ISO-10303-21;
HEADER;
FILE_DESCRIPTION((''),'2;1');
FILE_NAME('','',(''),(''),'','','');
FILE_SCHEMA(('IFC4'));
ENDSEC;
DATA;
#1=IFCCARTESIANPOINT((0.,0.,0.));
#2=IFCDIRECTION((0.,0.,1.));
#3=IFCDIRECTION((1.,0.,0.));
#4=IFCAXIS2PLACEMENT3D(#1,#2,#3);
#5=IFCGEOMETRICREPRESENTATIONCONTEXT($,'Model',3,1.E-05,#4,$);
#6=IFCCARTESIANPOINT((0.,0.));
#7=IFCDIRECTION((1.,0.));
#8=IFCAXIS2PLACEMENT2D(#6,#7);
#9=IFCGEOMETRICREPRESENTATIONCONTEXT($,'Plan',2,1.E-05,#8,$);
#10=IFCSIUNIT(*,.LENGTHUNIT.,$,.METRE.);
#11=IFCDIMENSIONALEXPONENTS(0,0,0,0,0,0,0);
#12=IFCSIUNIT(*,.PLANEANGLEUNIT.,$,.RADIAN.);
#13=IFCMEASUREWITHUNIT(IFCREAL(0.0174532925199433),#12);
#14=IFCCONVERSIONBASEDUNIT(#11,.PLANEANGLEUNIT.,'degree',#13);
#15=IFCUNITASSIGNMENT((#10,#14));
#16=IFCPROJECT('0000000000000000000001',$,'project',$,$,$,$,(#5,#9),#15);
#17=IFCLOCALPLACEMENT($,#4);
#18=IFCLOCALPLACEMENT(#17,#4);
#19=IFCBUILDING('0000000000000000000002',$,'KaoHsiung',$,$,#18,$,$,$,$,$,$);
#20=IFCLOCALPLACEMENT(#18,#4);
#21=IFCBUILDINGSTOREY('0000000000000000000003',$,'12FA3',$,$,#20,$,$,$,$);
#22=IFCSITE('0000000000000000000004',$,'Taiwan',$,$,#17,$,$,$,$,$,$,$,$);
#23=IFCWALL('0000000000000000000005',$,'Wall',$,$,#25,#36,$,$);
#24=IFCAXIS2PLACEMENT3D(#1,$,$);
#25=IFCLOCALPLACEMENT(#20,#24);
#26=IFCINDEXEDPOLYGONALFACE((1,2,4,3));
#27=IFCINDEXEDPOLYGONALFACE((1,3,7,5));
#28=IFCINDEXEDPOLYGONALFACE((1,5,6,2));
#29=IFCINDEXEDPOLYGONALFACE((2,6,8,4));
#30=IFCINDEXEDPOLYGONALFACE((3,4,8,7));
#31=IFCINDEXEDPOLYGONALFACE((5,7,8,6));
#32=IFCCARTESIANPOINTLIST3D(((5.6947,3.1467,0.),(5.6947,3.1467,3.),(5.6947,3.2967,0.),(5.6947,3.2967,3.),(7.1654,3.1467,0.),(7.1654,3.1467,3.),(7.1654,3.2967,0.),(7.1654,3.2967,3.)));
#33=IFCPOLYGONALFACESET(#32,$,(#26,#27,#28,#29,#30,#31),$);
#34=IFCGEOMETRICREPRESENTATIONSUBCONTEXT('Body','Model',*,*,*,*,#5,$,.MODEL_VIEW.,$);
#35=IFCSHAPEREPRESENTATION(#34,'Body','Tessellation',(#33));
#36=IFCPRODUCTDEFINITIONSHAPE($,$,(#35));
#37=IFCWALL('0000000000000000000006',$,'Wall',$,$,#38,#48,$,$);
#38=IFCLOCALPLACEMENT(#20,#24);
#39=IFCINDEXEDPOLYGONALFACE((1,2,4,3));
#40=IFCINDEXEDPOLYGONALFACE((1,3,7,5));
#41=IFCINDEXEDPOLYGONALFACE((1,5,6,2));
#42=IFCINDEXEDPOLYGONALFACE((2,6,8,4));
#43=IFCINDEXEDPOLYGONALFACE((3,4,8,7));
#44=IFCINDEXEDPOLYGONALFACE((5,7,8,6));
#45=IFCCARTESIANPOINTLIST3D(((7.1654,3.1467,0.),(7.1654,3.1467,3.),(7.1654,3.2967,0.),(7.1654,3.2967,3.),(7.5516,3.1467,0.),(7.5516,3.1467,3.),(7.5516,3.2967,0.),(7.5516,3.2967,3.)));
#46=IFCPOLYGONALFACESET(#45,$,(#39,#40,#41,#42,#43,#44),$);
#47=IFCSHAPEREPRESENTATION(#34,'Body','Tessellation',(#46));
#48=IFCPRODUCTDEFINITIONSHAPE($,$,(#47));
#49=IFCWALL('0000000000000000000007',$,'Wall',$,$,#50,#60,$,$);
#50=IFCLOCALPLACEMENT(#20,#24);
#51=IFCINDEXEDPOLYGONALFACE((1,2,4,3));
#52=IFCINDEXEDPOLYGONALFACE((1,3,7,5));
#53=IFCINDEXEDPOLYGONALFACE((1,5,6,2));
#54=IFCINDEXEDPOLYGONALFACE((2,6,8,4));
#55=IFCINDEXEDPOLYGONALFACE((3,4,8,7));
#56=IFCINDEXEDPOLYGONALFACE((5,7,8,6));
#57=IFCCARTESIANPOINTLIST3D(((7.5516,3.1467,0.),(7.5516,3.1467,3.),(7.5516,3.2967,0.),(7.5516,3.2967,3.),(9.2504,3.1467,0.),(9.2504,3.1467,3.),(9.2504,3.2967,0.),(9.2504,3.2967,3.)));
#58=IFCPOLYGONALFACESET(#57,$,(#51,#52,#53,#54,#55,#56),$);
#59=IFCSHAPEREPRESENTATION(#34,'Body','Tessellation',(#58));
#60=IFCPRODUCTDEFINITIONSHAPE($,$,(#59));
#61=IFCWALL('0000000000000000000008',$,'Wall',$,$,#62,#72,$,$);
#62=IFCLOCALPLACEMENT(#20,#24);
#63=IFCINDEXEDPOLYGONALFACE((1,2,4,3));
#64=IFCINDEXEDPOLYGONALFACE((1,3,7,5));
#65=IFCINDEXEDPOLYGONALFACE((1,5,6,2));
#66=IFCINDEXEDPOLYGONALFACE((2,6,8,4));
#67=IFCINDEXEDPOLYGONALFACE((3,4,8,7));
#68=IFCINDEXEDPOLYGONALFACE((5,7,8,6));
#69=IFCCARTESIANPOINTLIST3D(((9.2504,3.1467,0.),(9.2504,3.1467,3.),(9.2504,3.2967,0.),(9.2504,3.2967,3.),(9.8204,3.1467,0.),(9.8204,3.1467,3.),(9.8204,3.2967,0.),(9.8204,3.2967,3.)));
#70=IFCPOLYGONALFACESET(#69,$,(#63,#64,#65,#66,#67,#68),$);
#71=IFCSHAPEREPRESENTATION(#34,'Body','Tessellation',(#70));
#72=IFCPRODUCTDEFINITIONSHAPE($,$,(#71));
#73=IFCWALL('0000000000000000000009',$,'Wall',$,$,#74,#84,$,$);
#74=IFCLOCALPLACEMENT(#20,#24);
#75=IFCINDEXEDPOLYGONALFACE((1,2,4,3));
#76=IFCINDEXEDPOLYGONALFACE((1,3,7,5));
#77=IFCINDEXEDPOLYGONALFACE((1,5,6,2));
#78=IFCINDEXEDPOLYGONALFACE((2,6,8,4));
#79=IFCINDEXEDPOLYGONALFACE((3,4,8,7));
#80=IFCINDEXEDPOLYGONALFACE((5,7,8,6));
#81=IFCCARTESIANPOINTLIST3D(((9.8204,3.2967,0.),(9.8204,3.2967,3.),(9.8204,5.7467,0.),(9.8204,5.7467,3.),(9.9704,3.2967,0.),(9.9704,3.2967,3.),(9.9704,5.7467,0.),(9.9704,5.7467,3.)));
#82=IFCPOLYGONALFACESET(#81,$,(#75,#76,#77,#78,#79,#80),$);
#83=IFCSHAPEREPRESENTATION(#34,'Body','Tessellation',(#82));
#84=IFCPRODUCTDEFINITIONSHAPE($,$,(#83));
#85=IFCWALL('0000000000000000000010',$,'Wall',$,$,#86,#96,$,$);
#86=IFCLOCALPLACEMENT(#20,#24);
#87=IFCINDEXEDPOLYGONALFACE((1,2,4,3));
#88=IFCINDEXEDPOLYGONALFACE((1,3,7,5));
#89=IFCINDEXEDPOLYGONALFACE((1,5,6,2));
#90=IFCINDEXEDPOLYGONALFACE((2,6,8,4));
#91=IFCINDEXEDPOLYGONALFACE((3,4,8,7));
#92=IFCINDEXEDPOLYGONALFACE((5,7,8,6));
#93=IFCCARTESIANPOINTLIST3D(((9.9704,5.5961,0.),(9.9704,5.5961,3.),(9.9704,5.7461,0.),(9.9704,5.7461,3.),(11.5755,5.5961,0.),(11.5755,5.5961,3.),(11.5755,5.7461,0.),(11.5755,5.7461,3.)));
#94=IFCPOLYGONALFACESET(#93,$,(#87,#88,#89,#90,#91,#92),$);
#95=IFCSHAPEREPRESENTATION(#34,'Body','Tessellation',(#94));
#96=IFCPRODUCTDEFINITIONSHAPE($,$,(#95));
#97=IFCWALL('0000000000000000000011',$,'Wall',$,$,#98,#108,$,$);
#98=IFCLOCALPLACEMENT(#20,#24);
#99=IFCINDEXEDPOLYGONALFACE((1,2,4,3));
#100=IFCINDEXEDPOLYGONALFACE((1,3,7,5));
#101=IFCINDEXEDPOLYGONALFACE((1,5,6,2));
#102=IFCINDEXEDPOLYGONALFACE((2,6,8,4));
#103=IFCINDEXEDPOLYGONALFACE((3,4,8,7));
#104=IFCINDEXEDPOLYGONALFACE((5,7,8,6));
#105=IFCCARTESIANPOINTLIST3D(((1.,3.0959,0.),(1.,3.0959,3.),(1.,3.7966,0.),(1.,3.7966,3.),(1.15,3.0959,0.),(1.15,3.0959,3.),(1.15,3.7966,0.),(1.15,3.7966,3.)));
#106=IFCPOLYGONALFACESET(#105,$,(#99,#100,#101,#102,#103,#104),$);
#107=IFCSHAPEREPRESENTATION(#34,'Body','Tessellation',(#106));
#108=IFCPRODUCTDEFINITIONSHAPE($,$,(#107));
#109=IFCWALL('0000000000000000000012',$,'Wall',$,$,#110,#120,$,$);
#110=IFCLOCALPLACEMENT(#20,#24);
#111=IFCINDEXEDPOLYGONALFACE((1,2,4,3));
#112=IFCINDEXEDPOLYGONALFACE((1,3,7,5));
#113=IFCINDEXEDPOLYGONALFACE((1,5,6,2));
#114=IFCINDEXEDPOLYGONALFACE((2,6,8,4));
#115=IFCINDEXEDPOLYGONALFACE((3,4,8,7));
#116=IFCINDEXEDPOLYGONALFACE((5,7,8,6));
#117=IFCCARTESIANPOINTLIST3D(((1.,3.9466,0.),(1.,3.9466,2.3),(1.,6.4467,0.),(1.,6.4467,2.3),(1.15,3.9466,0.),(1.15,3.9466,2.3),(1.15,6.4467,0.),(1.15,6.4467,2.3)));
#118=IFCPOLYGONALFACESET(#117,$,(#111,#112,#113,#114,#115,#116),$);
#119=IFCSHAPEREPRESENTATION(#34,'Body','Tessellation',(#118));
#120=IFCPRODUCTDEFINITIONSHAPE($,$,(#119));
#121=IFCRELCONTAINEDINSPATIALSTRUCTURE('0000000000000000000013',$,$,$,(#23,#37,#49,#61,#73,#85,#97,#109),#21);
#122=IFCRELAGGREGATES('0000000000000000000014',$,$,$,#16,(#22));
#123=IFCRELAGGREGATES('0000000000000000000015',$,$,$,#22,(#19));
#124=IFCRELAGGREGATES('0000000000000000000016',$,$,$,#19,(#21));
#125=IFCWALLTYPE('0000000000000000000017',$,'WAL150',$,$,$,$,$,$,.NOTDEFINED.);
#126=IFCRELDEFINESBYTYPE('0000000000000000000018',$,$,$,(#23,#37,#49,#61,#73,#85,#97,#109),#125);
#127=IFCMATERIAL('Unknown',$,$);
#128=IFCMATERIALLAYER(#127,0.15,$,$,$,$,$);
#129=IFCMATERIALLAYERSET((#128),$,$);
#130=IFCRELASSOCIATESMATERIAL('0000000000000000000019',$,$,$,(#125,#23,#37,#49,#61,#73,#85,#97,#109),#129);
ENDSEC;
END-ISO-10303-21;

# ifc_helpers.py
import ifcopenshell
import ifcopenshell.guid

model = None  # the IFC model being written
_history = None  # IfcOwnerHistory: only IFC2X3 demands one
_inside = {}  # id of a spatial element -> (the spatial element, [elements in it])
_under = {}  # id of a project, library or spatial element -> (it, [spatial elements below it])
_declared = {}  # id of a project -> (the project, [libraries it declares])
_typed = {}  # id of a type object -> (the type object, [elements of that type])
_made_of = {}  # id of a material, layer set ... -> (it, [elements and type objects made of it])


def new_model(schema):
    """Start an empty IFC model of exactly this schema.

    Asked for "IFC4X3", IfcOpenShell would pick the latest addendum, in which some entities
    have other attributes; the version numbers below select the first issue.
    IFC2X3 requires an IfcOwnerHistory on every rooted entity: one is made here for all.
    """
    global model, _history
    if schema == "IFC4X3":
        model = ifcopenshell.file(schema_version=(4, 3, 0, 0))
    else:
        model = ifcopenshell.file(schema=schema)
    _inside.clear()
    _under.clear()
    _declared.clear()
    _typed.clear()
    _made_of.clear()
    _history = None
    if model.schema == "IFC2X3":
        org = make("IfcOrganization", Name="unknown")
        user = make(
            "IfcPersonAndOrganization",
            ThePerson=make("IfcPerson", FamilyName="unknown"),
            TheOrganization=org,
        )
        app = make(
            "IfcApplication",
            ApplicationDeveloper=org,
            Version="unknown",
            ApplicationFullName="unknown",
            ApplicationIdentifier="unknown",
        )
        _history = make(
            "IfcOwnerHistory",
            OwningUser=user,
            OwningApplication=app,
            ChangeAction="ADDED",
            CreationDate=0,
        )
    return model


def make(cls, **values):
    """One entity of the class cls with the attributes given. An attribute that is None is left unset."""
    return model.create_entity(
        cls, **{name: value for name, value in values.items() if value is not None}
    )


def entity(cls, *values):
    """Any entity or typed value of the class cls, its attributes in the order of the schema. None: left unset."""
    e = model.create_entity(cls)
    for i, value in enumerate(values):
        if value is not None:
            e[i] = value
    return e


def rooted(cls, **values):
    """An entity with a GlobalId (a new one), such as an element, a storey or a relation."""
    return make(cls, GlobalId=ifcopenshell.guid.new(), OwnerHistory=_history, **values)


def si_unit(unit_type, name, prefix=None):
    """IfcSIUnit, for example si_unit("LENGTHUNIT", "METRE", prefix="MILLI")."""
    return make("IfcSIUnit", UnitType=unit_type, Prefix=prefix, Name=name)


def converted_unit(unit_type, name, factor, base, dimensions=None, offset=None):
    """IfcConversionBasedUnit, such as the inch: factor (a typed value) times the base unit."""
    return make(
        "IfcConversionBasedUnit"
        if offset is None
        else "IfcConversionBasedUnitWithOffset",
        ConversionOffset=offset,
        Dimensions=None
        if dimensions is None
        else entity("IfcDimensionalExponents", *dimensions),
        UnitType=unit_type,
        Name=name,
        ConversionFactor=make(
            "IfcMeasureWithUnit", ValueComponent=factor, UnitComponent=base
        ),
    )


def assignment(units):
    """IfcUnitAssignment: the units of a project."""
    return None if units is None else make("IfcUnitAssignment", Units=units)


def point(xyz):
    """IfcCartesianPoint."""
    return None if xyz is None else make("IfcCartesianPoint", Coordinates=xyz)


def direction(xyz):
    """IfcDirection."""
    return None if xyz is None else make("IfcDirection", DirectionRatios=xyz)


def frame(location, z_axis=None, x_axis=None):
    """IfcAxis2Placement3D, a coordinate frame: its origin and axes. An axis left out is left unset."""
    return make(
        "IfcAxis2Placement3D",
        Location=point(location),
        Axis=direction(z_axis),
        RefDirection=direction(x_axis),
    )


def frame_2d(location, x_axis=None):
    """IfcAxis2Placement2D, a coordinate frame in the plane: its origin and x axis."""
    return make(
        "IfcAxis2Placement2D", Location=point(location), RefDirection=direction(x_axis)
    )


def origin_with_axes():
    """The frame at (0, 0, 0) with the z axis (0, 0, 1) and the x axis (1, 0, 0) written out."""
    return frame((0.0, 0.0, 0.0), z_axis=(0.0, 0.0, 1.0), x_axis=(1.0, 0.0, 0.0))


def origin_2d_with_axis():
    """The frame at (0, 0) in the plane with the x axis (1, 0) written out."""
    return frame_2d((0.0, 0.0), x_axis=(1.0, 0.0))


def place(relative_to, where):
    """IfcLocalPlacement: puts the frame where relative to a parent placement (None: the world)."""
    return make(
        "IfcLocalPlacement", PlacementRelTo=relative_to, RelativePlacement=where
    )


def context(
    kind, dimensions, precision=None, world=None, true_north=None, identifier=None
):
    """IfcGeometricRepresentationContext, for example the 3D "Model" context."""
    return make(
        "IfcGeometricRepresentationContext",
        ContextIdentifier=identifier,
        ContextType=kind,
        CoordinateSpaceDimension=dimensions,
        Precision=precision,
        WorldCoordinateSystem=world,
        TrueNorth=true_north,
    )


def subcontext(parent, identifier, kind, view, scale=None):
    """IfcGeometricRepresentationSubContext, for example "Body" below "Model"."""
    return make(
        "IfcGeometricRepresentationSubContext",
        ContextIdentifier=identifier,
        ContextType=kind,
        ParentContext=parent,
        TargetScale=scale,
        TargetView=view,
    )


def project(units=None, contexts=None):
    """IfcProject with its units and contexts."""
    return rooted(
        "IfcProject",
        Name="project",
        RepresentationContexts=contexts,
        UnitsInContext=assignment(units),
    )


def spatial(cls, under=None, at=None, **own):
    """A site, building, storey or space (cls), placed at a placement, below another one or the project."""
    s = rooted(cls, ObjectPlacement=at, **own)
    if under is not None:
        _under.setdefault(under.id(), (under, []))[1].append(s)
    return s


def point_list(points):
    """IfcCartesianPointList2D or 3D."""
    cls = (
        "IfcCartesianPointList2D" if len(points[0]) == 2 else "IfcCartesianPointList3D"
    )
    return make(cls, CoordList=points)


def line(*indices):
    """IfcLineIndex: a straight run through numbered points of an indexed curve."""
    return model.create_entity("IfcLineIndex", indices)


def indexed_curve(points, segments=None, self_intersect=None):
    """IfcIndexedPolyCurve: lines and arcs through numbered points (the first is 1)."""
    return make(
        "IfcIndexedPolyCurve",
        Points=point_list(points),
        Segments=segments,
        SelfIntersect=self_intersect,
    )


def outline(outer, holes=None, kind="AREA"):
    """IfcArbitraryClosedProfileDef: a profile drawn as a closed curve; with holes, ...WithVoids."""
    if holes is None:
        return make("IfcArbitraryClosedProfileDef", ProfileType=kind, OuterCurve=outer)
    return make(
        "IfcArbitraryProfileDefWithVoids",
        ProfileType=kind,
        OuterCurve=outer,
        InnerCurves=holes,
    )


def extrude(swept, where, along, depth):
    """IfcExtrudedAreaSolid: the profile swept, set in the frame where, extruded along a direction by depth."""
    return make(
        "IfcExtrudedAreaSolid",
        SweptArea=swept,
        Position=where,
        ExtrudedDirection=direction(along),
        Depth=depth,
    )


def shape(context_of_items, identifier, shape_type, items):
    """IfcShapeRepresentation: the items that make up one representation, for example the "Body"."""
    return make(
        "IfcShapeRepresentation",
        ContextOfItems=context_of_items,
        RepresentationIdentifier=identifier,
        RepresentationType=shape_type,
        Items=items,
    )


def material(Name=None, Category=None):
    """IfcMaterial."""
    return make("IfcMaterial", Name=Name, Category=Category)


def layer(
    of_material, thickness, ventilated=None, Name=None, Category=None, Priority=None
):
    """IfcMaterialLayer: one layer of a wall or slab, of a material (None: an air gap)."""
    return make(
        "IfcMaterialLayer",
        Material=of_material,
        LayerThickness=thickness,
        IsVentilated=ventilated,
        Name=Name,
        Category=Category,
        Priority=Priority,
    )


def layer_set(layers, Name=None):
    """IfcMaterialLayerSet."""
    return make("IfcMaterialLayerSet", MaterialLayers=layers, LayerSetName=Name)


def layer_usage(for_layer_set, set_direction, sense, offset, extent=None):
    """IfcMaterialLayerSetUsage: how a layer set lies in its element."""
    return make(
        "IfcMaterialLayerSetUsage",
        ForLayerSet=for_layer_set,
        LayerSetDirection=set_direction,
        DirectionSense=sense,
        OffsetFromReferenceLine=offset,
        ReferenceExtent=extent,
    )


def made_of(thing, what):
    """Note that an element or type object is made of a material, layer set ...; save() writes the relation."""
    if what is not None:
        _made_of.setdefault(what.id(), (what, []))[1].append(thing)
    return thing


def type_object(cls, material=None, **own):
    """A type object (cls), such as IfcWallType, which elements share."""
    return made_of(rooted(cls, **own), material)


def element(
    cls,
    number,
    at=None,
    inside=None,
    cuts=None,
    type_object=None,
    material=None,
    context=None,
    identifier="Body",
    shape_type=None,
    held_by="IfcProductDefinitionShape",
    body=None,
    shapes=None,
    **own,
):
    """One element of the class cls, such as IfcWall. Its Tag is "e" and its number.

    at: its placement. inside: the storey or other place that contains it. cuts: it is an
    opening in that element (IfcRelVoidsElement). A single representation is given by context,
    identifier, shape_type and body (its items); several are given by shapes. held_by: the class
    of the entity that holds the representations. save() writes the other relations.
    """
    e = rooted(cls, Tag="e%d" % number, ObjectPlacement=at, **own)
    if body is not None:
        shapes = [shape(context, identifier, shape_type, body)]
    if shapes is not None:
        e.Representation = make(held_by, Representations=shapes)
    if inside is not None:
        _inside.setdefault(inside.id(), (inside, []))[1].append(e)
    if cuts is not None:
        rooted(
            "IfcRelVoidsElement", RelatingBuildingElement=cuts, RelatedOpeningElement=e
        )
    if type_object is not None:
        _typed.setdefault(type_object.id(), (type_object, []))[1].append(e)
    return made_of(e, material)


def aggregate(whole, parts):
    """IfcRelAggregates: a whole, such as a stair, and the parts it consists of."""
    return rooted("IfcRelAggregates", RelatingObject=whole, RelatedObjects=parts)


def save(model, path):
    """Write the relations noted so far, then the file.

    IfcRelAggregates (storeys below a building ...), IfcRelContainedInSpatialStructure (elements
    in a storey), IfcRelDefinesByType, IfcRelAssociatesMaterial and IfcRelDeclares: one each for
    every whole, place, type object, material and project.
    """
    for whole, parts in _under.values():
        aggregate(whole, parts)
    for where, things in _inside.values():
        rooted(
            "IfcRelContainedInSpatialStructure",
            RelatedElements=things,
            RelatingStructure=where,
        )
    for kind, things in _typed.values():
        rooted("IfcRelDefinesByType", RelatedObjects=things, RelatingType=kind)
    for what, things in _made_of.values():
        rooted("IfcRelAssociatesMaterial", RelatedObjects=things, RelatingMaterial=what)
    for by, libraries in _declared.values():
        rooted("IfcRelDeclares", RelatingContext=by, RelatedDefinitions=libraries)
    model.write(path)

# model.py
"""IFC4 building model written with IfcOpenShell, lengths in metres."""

from ifc_helpers import new_model, entity, si_unit, converted_unit, frame, origin_with_axes, origin_2d_with_axis, place, context, subcontext, project, spatial, line, indexed_curve, outline, extrude, material, layer, layer_set, layer_usage, type_object, element, save


model = new_model("IFC4")

# Units and contexts
model_context = context("Model", 3, precision=1e-05, world=origin_with_axes())
plan_context = context("Plan", 2, precision=1e-05, world=origin_2d_with_axis())
body_context_1 = subcontext(model_context, "Body", "Model", "MODEL_VIEW")
ifc_project = project(units=[si_unit("LENGTHUNIT", "METRE"), converted_unit("PLANEANGLEUNIT", "degree", entity("IfcReal", 0.0174532925199433), si_unit("PLANEANGLEUNIT", "RADIAN"), dimensions=[0, 0, 0, 0, 0, 0, 0])], contexts=[model_context, plan_context])

# Site, building, storey
site_placement = place(None, origin_with_axes())
site = spatial("IfcSite", under=ifc_project, at=site_placement, Name="Taiwan")
building_placement = place(site_placement, origin_with_axes())
building = spatial("IfcBuilding", under=site, at=building_placement, Name="KaoHsiung")
storey_placement = place(building_placement, origin_with_axes())
storey = spatial("IfcBuildingStorey", under=building, at=storey_placement, Name="12FA3")

# Shared definitions
ifc_material = material(Name="Unknown")

# Shared definitions
ifc_layer_1 = layer(ifc_material, 0.15)
ifc_layer_set_1 = layer_set([ifc_layer_1])
wall_type_1 = type_object("IfcWallType", Name="WAL150", PredefinedType="NOTDEFINED", material=ifc_layer_set_1)

# Walls
ifc_layer_usage_1 = layer_usage(ifc_layer_set_1, "AXIS2", "POSITIVE", 0.0)
wall_1_placement = place(storey_placement, frame((5.6947, 3.1467, 0.0), z_axis=(0.0, 0.0, 1.0), x_axis=(1.0, 0.0, 0.0)))
element("IfcWall", 1, at=wall_1_placement, inside=storey, type_object=wall_type_1, material=ifc_layer_usage_1, Name="Wall", context=body_context_1, shape_type="SweptSolid", body=[
    extrude(outline(indexed_curve([(0.0, 0.0), (0.0, 0.15), (1.4706, 0.15), (1.4706, 0.0)], segments=[line(1, 2, 3, 4, 1)])), origin_with_axes(), (0.0, 0.0, 1.0), 3.0),
])
ifc_layer_usage_2 = layer_usage(ifc_layer_set_1, "AXIS2", "POSITIVE", 0.0)
wall_2_placement = place(storey_placement, frame((7.1654, 3.1467, 0.0), z_axis=(0.0, 0.0, 1.0), x_axis=(1.0, 0.0, 0.0)))
element("IfcWall", 2, at=wall_2_placement, inside=storey, type_object=wall_type_1, material=ifc_layer_usage_2, Name="Wall", context=body_context_1, shape_type="SweptSolid", body=[
    extrude(outline(indexed_curve([(0.0, 0.0), (0.0, 0.15), (0.3862, 0.15), (0.3862, 0.0)], segments=[line(1, 2, 3, 4, 1)])), origin_with_axes(), (0.0, 0.0, 1.0), 3.0),
])
ifc_layer_usage_3 = layer_usage(ifc_layer_set_1, "AXIS2", "POSITIVE", 0.0)
wall_3_placement = place(storey_placement, frame((7.5516, 3.1467, 0.0), z_axis=(0.0, 0.0, 1.0), x_axis=(1.0, 0.0, 0.0)))
element("IfcWall", 3, at=wall_3_placement, inside=storey, type_object=wall_type_1, material=ifc_layer_usage_3, Name="Wall", context=body_context_1, shape_type="SweptSolid", body=[
    extrude(outline(indexed_curve([(0.0, 0.0), (0.0, 0.15), (1.6987, 0.15), (1.6987, 0.0)], segments=[line(1, 2, 3, 4, 1)])), origin_with_axes(), (0.0, 0.0, 1.0), 3.0),
])
ifc_layer_usage_4 = layer_usage(ifc_layer_set_1, "AXIS2", "POSITIVE", 0.0)
wall_4_placement = place(storey_placement, frame((9.2504, 3.1467, 0.0), z_axis=(0.0, 0.0, 1.0), x_axis=(1.0, 0.0, 0.0)))
element("IfcWall", 4, at=wall_4_placement, inside=storey, type_object=wall_type_1, material=ifc_layer_usage_4, Name="Wall", context=body_context_1, shape_type="SweptSolid", body=[
    extrude(outline(indexed_curve([(0.0, 0.0), (0.0, 0.15), (0.57, 0.15), (0.57, 0.0)], segments=[line(1, 2, 3, 4, 1)])), origin_with_axes(), (0.0, 0.0, 1.0), 3.0),
])
ifc_layer_usage_5 = layer_usage(ifc_layer_set_1, "AXIS2", "POSITIVE", 0.0)
wall_5_placement = place(storey_placement, frame((9.9704, 3.2967, 0.0), z_axis=(0.0, 0.0, 1.0), x_axis=(0.0, 1.0, 0.0)))
element("IfcWall", 5, at=wall_5_placement, inside=storey, type_object=wall_type_1, material=ifc_layer_usage_5, Name="Wall", context=body_context_1, shape_type="SweptSolid", body=[
    extrude(outline(indexed_curve([(0.0, 0.0), (0.0, 0.15), (2.45, 0.15), (2.45, 0.0)], segments=[line(1, 2, 3, 4, 1)])), origin_with_axes(), (0.0, 0.0, 1.0), 3.0),
])
ifc_layer_usage_6 = layer_usage(ifc_layer_set_1, "AXIS2", "POSITIVE", 0.0)
wall_6_placement = place(storey_placement, frame((9.9704, 5.5961, 0.0), z_axis=(0.0, 0.0, 1.0), x_axis=(1.0, 0.0, 0.0)))
element("IfcWall", 6, at=wall_6_placement, inside=storey, type_object=wall_type_1, material=ifc_layer_usage_6, Name="Wall", context=body_context_1, shape_type="SweptSolid", body=[
    extrude(outline(indexed_curve([(0.0, 0.0), (0.0, 0.15), (1.6051, 0.15), (1.6051, 0.0)], segments=[line(1, 2, 3, 4, 1)])), origin_with_axes(), (0.0, 0.0, 1.0), 3.0),
])
ifc_layer_usage_7 = layer_usage(ifc_layer_set_1, "AXIS2", "POSITIVE", 0.0)
wall_7_placement = place(storey_placement, frame((1.0, 3.7966, 0.0), z_axis=(0.0, 0.0, 1.0), x_axis=(0.0, -1.0, 0.0)))
element("IfcWall", 7, at=wall_7_placement, inside=storey, type_object=wall_type_1, material=ifc_layer_usage_7, Name="Wall", context=body_context_1, shape_type="SweptSolid", body=[
    extrude(outline(indexed_curve([(0.0, 0.0), (0.0, 0.15), (0.7007, 0.15), (0.7007, 0.0)], segments=[line(1, 2, 3, 4, 1)])), origin_with_axes(), (0.0, 0.0, 1.0), 3.0),
])
ifc_layer_usage_8 = layer_usage(ifc_layer_set_1, "AXIS2", "POSITIVE", 0.0)
wall_8_placement = place(storey_placement, frame((1.0, 6.4467, 0.0), z_axis=(0.0, 0.0, 1.0), x_axis=(0.0, -1.0, 0.0)))
element("IfcWall", 8, at=wall_8_placement, inside=storey, type_object=wall_type_1, material=ifc_layer_usage_8, Name="Wall", context=body_context_1, shape_type="SweptSolid", body=[
    extrude(outline(indexed_curve([(0.0, 0.0), (0.0, 0.15), (2.5001, 0.15), (2.5001, 0.0)], segments=[line(1, 2, 3, 4, 1)])), origin_with_axes(), (0.0, 0.0, 1.0), 2.3),
])

save(model, "model.ifc")
